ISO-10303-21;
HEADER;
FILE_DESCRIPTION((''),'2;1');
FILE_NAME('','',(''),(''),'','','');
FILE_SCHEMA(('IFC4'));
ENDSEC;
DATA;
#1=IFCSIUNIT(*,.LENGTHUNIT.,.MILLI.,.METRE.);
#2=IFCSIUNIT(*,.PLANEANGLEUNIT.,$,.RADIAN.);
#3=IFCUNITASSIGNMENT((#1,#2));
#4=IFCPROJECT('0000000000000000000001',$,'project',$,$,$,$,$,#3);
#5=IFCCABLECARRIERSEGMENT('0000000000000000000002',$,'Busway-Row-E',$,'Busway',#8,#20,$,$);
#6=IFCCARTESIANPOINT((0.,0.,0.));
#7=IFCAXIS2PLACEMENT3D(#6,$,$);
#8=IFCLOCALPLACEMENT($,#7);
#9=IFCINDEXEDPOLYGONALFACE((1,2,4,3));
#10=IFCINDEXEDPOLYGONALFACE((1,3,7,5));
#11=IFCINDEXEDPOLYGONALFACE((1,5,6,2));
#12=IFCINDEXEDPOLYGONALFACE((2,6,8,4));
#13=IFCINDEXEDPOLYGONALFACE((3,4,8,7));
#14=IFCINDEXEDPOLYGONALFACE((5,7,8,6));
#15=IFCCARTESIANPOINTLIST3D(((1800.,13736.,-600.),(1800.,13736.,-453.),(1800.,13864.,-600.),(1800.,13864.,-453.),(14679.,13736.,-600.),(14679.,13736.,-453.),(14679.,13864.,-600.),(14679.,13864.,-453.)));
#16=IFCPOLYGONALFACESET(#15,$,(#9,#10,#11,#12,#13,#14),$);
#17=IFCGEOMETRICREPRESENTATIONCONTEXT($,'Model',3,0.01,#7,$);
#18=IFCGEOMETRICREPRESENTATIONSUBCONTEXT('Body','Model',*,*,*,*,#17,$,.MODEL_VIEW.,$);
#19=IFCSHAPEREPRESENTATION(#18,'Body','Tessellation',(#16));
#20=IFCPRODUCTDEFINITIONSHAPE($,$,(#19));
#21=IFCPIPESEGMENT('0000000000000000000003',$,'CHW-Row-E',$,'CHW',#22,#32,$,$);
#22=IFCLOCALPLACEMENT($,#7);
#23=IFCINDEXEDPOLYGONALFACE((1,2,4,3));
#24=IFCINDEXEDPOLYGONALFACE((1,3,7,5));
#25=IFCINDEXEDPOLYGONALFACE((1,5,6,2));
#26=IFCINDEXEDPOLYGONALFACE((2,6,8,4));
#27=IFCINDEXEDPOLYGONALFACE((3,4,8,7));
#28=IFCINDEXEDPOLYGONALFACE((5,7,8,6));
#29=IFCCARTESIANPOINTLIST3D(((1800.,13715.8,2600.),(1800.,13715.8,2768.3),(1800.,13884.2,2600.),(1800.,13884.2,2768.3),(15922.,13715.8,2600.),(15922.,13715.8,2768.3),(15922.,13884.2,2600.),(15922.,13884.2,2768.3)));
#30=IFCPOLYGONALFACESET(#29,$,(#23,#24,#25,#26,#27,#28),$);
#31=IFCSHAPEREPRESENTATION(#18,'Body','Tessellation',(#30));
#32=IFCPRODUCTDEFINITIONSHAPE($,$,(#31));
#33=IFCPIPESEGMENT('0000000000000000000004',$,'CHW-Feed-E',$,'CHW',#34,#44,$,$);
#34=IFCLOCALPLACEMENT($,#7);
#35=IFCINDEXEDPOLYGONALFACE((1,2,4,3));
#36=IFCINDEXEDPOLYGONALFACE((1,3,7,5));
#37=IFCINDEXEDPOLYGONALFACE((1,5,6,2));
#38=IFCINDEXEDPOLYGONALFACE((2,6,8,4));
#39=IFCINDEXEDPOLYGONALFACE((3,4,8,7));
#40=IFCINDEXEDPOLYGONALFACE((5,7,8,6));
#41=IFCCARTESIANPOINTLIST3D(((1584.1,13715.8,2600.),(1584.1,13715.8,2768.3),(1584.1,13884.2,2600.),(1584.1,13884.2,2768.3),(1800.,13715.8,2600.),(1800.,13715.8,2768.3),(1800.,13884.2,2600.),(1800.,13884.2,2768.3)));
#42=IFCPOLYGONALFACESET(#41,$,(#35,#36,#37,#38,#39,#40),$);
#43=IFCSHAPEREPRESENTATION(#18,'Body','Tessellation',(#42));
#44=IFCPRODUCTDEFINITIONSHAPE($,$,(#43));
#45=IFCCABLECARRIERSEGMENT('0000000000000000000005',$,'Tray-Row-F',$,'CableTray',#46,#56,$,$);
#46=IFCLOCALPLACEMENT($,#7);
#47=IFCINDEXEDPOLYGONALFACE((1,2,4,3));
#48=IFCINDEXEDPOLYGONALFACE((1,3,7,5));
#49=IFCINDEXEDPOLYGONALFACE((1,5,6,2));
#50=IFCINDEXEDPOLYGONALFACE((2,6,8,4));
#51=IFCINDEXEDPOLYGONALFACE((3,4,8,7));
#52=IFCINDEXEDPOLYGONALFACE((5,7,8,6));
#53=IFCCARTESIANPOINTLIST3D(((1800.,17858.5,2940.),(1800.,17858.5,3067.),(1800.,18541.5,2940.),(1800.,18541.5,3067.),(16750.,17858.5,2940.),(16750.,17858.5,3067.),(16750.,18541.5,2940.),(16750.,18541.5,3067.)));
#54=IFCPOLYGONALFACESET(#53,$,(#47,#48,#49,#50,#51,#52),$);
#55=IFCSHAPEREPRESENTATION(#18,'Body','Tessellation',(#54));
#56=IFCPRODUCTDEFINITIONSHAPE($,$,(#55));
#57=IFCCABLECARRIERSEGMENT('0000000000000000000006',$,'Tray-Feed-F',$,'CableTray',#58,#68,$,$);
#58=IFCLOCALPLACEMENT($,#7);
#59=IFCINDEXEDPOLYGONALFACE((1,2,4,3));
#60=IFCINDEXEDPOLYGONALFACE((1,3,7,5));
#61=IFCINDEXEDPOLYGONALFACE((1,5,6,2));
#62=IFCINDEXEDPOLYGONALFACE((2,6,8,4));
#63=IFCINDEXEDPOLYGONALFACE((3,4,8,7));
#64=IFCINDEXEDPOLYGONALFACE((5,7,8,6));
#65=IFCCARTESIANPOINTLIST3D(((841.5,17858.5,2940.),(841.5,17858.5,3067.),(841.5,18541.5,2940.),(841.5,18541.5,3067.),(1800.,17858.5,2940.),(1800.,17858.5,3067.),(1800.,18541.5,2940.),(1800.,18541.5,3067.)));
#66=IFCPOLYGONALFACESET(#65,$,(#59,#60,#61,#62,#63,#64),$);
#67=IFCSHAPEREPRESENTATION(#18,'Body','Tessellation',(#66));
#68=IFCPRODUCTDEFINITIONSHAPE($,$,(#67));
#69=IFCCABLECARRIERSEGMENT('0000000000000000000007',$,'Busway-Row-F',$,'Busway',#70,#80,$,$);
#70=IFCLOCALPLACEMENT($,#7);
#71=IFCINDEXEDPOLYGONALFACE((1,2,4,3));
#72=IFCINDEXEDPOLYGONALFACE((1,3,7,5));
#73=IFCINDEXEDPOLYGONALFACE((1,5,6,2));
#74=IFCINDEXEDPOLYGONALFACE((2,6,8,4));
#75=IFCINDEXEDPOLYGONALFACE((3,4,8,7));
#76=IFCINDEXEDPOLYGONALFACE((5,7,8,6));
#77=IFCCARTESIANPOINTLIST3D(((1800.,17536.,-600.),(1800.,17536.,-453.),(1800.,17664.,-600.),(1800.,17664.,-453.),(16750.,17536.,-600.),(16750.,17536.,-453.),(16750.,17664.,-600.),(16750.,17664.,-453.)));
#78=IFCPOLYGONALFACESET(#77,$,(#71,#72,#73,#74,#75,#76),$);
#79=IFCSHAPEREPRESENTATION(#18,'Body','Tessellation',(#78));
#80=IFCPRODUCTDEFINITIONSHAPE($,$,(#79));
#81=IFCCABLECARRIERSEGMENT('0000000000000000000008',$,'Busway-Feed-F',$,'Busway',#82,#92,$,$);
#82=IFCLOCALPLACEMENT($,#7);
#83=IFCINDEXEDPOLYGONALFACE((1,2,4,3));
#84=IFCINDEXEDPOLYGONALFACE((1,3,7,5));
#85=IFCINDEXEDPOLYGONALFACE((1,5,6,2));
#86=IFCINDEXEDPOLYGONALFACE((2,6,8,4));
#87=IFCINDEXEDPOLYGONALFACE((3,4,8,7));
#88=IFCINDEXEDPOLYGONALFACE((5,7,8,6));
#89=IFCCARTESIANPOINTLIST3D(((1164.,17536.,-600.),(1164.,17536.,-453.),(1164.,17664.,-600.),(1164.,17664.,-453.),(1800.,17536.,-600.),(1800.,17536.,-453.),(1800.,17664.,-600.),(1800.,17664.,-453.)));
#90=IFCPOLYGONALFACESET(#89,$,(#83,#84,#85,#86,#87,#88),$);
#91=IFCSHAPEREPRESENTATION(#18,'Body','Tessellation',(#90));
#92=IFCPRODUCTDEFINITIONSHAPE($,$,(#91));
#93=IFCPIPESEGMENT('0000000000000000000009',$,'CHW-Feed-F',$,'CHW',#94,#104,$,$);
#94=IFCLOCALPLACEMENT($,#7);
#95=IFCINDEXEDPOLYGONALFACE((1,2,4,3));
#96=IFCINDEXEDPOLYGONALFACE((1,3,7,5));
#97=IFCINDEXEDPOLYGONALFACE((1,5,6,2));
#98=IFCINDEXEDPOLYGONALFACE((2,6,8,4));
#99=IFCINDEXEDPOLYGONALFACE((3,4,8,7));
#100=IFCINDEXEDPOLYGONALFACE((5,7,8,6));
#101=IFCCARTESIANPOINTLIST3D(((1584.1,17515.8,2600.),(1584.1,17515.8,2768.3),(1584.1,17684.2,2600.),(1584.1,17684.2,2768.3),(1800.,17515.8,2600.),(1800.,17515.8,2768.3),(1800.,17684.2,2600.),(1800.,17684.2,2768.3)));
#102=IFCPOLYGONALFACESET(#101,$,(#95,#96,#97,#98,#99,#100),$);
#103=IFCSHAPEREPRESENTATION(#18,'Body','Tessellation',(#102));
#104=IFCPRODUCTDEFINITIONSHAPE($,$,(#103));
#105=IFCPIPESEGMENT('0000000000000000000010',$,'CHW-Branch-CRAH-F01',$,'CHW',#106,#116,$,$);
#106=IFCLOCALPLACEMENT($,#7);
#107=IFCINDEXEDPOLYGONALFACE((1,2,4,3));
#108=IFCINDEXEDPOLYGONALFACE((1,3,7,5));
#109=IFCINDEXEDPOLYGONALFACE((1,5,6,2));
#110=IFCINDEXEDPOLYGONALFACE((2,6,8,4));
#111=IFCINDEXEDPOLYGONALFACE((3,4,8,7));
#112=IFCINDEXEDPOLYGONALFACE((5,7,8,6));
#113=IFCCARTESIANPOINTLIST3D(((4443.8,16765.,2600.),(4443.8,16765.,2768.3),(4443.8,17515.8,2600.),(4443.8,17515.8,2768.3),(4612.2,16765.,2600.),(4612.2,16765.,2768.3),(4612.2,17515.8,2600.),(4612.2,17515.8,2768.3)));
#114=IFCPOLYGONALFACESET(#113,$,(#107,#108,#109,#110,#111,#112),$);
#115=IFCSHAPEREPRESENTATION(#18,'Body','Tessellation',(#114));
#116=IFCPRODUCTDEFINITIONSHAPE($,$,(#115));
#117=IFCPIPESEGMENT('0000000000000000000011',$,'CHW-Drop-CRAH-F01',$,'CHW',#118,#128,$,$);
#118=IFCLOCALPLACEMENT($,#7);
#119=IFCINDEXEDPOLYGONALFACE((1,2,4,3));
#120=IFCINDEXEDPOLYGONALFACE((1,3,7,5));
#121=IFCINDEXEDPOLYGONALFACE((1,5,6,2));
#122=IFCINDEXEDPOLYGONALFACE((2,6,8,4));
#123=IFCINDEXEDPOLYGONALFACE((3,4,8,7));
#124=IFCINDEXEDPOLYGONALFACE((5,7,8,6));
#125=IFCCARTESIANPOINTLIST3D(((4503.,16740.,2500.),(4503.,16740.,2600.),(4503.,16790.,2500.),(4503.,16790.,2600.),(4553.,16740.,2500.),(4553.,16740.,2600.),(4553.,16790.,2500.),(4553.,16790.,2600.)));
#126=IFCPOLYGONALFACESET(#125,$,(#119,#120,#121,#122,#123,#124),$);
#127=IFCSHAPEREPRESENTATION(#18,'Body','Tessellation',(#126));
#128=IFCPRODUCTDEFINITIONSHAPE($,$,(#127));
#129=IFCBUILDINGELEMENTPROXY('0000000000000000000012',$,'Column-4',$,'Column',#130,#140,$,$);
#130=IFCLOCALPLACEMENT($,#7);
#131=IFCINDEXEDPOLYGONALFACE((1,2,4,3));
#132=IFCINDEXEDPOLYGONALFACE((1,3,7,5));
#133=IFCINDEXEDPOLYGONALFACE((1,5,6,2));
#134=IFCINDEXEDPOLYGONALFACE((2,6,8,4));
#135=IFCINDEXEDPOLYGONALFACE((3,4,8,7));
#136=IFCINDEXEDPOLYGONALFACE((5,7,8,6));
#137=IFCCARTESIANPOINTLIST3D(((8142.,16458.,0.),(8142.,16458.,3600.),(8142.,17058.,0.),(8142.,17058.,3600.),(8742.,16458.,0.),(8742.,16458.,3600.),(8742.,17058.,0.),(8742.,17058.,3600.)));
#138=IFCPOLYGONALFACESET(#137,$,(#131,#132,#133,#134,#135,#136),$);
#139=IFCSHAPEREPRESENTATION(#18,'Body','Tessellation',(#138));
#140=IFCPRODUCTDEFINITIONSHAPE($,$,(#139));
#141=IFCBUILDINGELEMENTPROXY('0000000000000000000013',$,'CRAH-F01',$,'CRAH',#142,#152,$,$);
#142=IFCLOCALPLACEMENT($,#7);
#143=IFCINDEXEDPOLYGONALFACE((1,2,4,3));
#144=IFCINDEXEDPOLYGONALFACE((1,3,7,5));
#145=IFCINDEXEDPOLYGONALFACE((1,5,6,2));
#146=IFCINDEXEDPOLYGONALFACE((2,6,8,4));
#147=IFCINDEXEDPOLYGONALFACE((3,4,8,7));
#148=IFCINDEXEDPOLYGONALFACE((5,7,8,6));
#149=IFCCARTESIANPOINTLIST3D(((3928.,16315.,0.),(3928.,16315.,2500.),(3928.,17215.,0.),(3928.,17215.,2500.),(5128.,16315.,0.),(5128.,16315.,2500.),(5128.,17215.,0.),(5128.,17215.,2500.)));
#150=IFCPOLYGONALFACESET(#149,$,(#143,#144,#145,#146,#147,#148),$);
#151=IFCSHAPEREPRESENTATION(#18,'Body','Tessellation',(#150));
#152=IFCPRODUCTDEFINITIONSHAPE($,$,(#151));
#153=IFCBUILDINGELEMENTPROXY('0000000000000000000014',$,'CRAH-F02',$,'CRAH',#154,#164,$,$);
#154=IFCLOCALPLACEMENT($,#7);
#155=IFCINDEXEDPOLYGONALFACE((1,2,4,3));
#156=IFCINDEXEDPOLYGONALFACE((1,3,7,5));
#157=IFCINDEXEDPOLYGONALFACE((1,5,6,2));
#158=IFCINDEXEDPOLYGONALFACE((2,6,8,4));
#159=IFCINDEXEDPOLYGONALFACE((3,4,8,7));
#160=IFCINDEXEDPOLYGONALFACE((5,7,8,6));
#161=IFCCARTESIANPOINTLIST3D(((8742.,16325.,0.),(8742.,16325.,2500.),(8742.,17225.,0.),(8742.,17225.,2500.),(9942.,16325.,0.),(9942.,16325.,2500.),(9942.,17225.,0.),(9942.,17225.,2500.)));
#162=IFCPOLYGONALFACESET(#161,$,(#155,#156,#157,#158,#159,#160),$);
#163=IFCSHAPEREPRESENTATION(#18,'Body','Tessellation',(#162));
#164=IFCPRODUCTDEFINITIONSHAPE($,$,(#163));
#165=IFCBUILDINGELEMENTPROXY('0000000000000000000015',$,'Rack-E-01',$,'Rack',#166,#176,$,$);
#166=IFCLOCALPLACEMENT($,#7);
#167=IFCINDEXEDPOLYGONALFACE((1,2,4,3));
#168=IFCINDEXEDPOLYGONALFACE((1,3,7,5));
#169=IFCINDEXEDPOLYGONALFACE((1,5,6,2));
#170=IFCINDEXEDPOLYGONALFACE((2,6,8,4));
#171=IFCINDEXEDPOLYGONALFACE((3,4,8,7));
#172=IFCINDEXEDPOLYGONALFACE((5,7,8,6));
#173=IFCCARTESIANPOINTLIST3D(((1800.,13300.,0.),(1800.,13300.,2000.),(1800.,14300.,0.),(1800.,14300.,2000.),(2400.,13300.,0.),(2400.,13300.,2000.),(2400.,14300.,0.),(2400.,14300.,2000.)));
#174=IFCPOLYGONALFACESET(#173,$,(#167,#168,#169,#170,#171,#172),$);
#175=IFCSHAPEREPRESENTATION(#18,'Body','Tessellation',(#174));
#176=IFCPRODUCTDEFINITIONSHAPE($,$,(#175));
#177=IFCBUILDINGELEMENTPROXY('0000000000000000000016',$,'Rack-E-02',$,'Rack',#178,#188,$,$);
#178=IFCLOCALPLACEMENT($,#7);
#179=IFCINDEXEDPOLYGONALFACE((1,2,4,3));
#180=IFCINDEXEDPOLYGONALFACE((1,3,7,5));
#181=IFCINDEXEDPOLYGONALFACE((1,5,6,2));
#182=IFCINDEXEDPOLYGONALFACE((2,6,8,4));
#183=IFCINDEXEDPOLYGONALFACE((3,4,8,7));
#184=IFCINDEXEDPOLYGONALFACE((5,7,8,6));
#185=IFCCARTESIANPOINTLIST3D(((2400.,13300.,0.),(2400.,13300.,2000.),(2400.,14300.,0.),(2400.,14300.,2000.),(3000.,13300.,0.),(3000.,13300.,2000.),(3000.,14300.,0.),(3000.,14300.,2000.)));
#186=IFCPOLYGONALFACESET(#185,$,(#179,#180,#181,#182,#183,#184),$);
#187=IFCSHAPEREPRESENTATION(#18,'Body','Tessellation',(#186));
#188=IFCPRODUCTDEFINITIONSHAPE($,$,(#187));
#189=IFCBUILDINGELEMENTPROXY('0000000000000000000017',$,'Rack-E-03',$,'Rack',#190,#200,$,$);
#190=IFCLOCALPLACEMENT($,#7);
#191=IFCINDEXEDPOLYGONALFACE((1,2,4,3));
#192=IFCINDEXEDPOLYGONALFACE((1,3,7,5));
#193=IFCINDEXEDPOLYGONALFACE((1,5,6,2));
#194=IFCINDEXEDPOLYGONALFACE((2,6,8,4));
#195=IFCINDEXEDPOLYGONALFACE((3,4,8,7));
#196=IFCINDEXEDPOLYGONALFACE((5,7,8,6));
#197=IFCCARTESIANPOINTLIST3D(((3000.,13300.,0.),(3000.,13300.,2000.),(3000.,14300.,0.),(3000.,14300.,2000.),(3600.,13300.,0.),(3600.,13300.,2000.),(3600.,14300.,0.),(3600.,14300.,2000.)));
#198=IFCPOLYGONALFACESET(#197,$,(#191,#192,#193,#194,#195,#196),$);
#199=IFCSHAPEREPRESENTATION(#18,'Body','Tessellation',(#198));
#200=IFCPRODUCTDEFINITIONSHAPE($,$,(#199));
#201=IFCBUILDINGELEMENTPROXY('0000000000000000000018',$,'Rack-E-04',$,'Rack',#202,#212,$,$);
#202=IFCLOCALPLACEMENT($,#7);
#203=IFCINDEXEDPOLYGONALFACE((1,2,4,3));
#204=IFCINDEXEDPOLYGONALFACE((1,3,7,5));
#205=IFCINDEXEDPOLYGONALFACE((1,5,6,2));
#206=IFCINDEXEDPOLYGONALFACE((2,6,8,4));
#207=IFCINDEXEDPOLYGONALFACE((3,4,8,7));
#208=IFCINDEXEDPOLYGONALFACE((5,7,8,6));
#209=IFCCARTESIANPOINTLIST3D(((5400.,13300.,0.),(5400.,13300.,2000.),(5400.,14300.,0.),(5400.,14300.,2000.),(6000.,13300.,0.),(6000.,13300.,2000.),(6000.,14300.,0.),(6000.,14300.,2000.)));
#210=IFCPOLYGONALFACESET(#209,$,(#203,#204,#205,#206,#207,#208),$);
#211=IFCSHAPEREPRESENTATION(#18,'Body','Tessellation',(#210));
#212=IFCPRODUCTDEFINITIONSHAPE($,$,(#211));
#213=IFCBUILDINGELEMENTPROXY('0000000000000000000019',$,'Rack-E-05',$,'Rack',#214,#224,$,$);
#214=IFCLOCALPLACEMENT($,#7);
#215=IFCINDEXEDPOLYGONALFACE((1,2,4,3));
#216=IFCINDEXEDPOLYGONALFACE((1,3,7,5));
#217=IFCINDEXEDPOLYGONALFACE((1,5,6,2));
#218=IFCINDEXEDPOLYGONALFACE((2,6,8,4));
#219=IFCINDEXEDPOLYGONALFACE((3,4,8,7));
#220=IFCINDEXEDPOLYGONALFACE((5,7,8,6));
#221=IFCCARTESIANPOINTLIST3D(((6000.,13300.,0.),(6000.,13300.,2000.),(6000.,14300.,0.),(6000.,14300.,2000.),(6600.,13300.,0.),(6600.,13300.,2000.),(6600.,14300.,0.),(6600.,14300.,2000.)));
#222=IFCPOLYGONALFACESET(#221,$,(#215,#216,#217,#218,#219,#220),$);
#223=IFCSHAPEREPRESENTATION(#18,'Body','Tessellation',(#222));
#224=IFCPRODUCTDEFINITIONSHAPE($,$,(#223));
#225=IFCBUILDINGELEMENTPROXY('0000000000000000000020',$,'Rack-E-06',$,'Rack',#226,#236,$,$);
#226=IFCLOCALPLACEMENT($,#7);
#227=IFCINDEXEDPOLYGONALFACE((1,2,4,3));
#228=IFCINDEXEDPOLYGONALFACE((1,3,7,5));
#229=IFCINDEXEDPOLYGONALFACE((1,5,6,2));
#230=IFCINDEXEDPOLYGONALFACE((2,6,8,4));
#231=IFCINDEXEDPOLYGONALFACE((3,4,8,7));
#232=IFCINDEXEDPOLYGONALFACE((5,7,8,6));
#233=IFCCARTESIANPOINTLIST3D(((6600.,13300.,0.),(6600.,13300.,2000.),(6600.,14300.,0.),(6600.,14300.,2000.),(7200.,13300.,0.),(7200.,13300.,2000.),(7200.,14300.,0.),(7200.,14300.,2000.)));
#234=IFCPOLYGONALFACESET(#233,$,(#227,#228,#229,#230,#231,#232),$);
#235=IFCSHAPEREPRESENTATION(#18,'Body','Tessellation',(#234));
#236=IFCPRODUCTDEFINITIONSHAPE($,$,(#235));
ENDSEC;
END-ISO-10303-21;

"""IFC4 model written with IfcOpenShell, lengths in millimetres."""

from ifc_helpers import new_model, si_unit, frame, origin, place, context, subcontext, project, rectangle, extrude, element, save


model = new_model("IFC4")

# Units and contexts
model_context = context("Model", 3, precision=0.01, world=origin())
body_context = subcontext(model_context, "Body", "Model", "MODEL_VIEW")
ifc_project = project(units=[si_unit("LENGTHUNIT", "METRE", prefix="MILLI"), si_unit("PLANEANGLEUNIT", "RADIAN")])

# Cable carrier segment
placement = place(None, origin())
cable_carrier_segment_1_placement = place(placement, frame((8239.5, 13800.0, -600.0)))
element("IfcCableCarrierSegment", 1, at=cable_carrier_segment_1_placement, Name="Busway-Row-E", ObjectType="Busway", context=body_context, shape_type="SweptSolid", body=[
    extrude(rectangle(XDim=12879.0, YDim=128.0), origin(), (0.0, 0.0, 1.0), 147.0),
])

# Pipe segments
pipe_segment_1_placement = place(placement, frame((8861.0, 13800.0, 2600.0)))
element("IfcPipeSegment", 2, at=pipe_segment_1_placement, Name="CHW-Row-E", ObjectType="CHW", context=body_context, shape_type="SweptSolid", body=[
    extrude(rectangle(XDim=14122.0, YDim=168.3), origin(), (0.0, 0.0, 1.0), 168.3),
])
pipe_segment_2_placement = place(placement, frame((1692.1, 13800.0, 2600.0)))
element("IfcPipeSegment", 3, at=pipe_segment_2_placement, Name="CHW-Feed-E", ObjectType="CHW", context=body_context, shape_type="SweptSolid", body=[
    extrude(rectangle(XDim=215.8, YDim=168.3), origin(), (0.0, 0.0, 1.0), 168.3),
])

# Cable carrier segments
cable_carrier_segment_2_placement = place(placement, frame((9275.0, 18200.0, 2940.0)))
element("IfcCableCarrierSegment", 4, at=cable_carrier_segment_2_placement, Name="Tray-Row-F", ObjectType="CableTray", context=body_context, shape_type="SweptSolid", body=[
    extrude(rectangle(XDim=14950.0, YDim=683.0), origin(), (0.0, 0.0, 1.0), 127.0),
])
cable_carrier_segment_3_placement = place(placement, frame((1320.8, 18200.0, 2940.0)))
element("IfcCableCarrierSegment", 5, at=cable_carrier_segment_3_placement, Name="Tray-Feed-F", ObjectType="CableTray", context=body_context, shape_type="SweptSolid", body=[
    extrude(rectangle(XDim=958.5, YDim=683.0), origin(), (0.0, 0.0, 1.0), 127.0),
])
cable_carrier_segment_4_placement = place(placement, frame((9275.0, 17600.0, -600.0)))
element("IfcCableCarrierSegment", 6, at=cable_carrier_segment_4_placement, Name="Busway-Row-F", ObjectType="Busway", context=body_context, shape_type="SweptSolid", body=[
    extrude(rectangle(XDim=14950.0, YDim=128.0), origin(), (0.0, 0.0, 1.0), 147.0),
])
cable_carrier_segment_5_placement = place(placement, frame((1482.0, 17600.0, -600.0)))
element("IfcCableCarrierSegment", 7, at=cable_carrier_segment_5_placement, Name="Busway-Feed-F", ObjectType="Busway", context=body_context, shape_type="SweptSolid", body=[
    extrude(rectangle(XDim=636.0, YDim=128.0), origin(), (0.0, 0.0, 1.0), 147.0),
])

# Pipe segments
pipe_segment_3_placement = place(placement, frame((1692.1, 17600.0, 2600.0)))
element("IfcPipeSegment", 8, at=pipe_segment_3_placement, Name="CHW-Feed-F", ObjectType="CHW", context=body_context, shape_type="SweptSolid", body=[
    extrude(rectangle(XDim=215.8, YDim=168.3), origin(), (0.0, 0.0, 1.0), 168.3),
])
pipe_segment_4_placement = place(placement, frame((4528.0, 17140.4, 2600.0)))
element("IfcPipeSegment", 9, at=pipe_segment_4_placement, Name="CHW-Branch-CRAH-F01", ObjectType="CHW", context=body_context, shape_type="SweptSolid", body=[
    extrude(rectangle(XDim=168.3, YDim=750.8), origin(), (0.0, 0.0, 1.0), 168.3),
])
pipe_segment_5_placement = place(placement, frame((4528.0, 16765.0, 2500.0)))
element("IfcPipeSegment", 10, at=pipe_segment_5_placement, Name="CHW-Drop-CRAH-F01", ObjectType="CHW", context=body_context, shape_type="SweptSolid", body=[
    extrude(rectangle(XDim=50.0, YDim=50.0), origin(), (0.0, 0.0, 1.0), 100.0),
])

# Building element proxies
proxy_placement = place(placement, frame((8442.0, 16758.0, 0.0)))
element("IfcBuildingElementProxy", 11, at=proxy_placement, Name="Column-4", ObjectType="Column", context=body_context, shape_type="SweptSolid", body=[
    extrude(rectangle(XDim=600.0, YDim=600.0), origin(), (0.0, 0.0, 1.0), 3600.0),
])
for number, where, name in (
    (12, (4528.0, 16765.0, 0.0), "CRAH-F01"),
    (13, (9342.0, 16775.0, 0.0), "CRAH-F02"),
):
    element("IfcBuildingElementProxy", number, at=place(placement, frame(where)), Name=name, ObjectType="CRAH", context=body_context, shape_type="SweptSolid", body=[
        extrude(rectangle(XDim=1200.0, YDim=900.0), origin(), (0.0, 0.0, 1.0), 2500.0),
    ])
for number, where, name in (
    (14, (2100.0, 13800.0, 0.0), "Rack-E-01"),
    (15, (2700.0, 13800.0, 0.0), "Rack-E-02"),
    (16, (3300.0, 13800.0, 0.0), "Rack-E-03"),
    (17, (5700.0, 13800.0, 0.0), "Rack-E-04"),
    (18, (6300.0, 13800.0, 0.0), "Rack-E-05"),
    (19, (6900.0, 13800.0, 0.0), "Rack-E-06"),
):
    element("IfcBuildingElementProxy", number, at=place(placement, frame(where)), Name=name, ObjectType="Rack", context=body_context, shape_type="SweptSolid", body=[
        extrude(rectangle(XDim=600.0, YDim=1000.0), origin(), (0.0, 0.0, 1.0), 2000.0),
    ])

save(model, "model.ifc")
